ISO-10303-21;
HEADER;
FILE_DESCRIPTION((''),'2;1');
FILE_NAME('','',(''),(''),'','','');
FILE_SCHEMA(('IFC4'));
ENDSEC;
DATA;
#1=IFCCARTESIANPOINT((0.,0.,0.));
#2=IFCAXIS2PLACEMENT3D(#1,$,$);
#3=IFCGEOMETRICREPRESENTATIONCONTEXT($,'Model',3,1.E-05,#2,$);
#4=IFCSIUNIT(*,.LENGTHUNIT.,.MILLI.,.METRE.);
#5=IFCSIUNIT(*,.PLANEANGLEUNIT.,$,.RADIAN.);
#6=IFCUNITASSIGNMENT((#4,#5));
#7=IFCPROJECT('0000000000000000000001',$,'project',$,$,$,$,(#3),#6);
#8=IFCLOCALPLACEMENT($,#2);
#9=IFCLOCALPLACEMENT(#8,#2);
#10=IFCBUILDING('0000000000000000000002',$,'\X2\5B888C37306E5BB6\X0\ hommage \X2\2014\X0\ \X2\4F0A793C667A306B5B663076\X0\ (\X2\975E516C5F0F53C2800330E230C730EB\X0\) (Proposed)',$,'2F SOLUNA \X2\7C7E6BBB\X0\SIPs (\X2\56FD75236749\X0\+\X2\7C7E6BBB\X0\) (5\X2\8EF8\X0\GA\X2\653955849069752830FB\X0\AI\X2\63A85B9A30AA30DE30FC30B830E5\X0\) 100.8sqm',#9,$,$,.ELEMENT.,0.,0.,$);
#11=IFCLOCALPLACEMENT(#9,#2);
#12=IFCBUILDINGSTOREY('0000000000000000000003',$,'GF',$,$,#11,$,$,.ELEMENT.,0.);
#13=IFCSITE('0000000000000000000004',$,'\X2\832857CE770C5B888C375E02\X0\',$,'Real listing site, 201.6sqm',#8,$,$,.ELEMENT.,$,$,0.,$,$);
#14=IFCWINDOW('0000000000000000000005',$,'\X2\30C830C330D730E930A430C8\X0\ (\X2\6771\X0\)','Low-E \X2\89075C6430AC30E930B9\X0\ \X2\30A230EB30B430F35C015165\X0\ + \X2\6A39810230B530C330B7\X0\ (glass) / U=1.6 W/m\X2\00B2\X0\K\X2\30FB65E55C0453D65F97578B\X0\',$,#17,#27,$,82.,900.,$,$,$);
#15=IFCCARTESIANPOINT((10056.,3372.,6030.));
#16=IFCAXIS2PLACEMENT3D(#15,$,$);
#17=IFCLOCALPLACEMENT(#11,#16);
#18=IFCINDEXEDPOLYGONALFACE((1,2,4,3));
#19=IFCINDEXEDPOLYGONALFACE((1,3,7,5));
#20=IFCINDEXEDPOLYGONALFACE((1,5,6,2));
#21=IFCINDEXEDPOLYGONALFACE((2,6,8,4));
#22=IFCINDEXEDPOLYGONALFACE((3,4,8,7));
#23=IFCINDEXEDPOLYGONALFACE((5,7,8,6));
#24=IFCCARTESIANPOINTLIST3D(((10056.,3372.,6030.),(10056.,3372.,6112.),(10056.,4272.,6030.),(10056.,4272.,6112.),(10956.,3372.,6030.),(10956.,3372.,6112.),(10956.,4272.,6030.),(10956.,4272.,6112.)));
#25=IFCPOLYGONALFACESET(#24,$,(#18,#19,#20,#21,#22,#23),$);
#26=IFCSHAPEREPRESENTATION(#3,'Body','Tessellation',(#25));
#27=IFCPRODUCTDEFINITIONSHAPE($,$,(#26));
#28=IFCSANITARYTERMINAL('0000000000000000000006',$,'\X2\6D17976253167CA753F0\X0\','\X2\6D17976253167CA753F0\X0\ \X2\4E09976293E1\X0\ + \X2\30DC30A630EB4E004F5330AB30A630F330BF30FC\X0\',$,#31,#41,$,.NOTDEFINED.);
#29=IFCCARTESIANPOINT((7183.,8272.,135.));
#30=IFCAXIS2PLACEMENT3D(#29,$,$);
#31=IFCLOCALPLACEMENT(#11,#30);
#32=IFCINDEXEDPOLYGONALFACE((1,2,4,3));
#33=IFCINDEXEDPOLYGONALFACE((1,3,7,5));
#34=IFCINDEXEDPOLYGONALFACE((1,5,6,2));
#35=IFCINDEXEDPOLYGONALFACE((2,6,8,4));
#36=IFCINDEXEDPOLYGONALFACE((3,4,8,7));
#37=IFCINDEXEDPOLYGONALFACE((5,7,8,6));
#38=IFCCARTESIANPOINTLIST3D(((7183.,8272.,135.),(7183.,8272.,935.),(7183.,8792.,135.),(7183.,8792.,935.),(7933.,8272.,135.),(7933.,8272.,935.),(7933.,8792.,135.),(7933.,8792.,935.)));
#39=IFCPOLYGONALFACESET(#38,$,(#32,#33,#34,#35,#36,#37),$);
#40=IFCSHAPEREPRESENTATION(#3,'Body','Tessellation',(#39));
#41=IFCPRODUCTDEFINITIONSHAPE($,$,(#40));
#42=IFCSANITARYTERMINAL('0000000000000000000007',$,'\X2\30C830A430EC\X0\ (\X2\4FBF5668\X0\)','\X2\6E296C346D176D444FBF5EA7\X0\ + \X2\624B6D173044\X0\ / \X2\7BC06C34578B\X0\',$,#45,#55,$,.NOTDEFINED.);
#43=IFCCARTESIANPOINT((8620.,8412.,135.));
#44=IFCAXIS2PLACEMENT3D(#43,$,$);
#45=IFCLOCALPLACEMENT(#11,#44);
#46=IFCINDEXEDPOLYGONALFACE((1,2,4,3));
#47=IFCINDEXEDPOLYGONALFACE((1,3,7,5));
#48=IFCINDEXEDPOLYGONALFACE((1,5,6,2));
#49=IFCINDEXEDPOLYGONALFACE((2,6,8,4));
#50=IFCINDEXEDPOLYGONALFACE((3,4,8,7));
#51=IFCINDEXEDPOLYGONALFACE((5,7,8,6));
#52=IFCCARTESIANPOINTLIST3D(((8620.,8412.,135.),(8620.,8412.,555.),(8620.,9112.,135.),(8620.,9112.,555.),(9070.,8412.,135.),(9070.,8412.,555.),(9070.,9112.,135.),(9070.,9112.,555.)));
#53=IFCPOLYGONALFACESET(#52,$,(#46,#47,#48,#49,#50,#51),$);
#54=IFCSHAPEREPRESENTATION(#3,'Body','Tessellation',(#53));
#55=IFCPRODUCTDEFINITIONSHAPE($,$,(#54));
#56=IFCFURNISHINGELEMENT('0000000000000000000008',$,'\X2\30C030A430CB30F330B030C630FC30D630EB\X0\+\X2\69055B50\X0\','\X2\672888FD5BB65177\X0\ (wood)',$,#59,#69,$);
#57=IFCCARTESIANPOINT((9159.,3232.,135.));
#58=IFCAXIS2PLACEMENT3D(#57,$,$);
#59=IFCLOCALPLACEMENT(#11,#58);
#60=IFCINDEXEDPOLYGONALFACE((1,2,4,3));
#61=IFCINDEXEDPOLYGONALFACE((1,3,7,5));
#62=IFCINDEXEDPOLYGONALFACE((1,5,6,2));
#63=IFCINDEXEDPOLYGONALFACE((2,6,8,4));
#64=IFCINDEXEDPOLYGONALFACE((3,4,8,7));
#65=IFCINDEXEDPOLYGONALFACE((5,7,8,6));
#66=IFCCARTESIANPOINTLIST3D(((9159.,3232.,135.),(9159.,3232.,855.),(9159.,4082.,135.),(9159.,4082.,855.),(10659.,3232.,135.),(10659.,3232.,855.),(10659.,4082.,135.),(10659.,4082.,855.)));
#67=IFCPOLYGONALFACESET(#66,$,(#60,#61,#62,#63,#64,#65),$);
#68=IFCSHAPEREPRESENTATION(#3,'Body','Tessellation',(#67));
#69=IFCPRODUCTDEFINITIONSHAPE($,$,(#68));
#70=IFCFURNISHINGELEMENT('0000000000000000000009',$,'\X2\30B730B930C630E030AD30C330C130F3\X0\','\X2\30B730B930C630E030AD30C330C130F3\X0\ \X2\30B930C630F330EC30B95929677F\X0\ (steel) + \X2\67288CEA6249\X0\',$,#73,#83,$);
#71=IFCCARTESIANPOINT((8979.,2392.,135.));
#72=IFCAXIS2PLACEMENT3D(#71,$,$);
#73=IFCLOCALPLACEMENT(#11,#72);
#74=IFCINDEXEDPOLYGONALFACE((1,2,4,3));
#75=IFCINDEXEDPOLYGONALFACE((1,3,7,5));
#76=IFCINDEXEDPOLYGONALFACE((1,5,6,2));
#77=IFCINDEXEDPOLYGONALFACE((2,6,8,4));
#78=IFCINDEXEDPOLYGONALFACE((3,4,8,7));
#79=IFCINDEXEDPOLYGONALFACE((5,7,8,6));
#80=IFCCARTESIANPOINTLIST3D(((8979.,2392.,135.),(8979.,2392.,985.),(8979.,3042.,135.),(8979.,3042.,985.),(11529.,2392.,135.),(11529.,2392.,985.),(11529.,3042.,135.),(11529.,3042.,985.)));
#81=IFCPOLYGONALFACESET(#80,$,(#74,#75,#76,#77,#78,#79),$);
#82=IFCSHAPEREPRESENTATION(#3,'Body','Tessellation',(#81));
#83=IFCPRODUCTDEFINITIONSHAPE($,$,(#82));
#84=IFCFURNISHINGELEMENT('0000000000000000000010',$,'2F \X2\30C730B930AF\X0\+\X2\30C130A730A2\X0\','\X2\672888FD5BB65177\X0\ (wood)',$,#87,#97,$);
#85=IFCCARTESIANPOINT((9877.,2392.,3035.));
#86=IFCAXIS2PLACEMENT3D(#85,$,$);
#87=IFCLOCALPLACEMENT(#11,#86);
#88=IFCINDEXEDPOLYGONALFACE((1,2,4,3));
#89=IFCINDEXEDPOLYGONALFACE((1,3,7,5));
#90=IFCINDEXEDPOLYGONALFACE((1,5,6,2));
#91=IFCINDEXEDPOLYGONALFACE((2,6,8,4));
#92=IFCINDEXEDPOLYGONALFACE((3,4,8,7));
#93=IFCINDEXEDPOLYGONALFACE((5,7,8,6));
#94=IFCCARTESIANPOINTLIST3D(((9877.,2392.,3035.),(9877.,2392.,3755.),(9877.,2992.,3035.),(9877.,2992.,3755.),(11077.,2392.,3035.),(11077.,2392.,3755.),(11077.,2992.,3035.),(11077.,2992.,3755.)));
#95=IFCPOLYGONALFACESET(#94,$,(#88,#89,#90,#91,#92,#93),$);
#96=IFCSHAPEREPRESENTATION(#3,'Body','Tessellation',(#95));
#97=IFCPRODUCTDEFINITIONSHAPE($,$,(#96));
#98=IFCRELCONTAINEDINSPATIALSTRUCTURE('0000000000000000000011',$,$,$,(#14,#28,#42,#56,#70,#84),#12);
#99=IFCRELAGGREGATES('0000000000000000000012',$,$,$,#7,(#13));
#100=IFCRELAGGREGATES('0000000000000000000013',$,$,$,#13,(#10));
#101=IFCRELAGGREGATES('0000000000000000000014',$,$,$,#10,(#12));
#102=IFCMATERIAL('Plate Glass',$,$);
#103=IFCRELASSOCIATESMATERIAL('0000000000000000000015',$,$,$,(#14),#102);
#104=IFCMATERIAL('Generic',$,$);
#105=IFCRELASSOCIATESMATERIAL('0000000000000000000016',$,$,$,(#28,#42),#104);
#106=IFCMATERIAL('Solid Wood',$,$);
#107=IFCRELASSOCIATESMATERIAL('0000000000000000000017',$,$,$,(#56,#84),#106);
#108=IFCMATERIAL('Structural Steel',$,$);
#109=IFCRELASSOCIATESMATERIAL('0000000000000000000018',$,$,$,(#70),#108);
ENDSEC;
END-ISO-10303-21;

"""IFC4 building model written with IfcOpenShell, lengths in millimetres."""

from ifc_helpers import new_model, si_unit, frame, frame_2d, origin, place, context, project, spatial, rectangle, extrude, material, element, save


model = new_model("IFC4")

# Units and contexts
model_context = context("Model", 3, precision=1e-05, world=origin())
ifc_project = project(units=[si_unit("LENGTHUNIT", "METRE", prefix="MILLI"), si_unit("PLANEANGLEUNIT", "RADIAN")], contexts=[model_context])

# Site, building, storey
site_placement = place(None, origin())
site = spatial("IfcSite", under=ifc_project, at=site_placement, Name="茨城県守谷市", ObjectType="Real listing site, 201.6sqm", CompositionType="ELEMENT", RefElevation=0.0)
building_placement = place(site_placement, origin())
building = spatial("IfcBuilding", under=site, at=building_placement, Name="守谷の家 hommage — 伊礼智に学ぶ (非公式参考モデル) (Proposed)", ObjectType="2F SOLUNA 籾殻SIPs (国産杉+籾殻) (5軸GA改善適用・AI推定オマージュ) 100.8sqm", CompositionType="ELEMENT", ElevationOfRefHeight=0.0, ElevationOfTerrain=0.0)
storey_placement = place(building_placement, origin())
storey = spatial("IfcBuildingStorey", under=building, at=storey_placement, Name="GF", CompositionType="ELEMENT", Elevation=0.0)

# Shared definitions
ifc_material_1 = material(Name="Solid Wood")

# Shared definitions
ifc_material_2 = material(Name="Plate Glass")

# Window
window_1_placement = place(storey_placement, frame((10056.0, 3372.0, 6030.0)))
element("IfcWindow", 1, at=window_1_placement, inside=storey, material=ifc_material_2, Name="トップライト (東)", Description="Low-E 複層ガラス アルゴン封入 + 樹脂サッシ (glass) / U=1.6 W/m²K・日射取得型", OverallHeight=82.0, OverallWidth=900.0, context=model_context, shape_type="SweptSolid", body=[
    extrude(rectangle(XDim=900.0, YDim=900.0, at=frame_2d((450.0, 450.0))), frame((10056.0, 3372.0, 6030.0)), (0.0, 0.0, 1.0), 82.0),
])

# Sanitary terminals
ifc_material_3 = material(Name="Generic")
sanitary_terminal_1_placement = place(storey_placement, frame((7183.0, 8272.0, 135.0)))
element("IfcSanitaryTerminal", 2, at=sanitary_terminal_1_placement, inside=storey, material=ifc_material_3, Name="洗面化粧台", Description="洗面化粧台 三面鏡 + ボウル一体カウンター", PredefinedType="NOTDEFINED", context=model_context, shape_type="SweptSolid", body=[
    extrude(rectangle(XDim=750.0, YDim=520.0, at=frame_2d((375.0, 260.0))), frame((7183.0, 8272.0, 135.0)), (0.0, 0.0, 1.0), 800.0),
])
sanitary_terminal_2_placement = place(storey_placement, frame((8620.0, 8412.0, 135.0)))
element("IfcSanitaryTerminal", 3, at=sanitary_terminal_2_placement, inside=storey, material=ifc_material_3, Name="トイレ (便器)", Description="温水洗浄便座 + 手洗い / 節水型", PredefinedType="NOTDEFINED", context=model_context, shape_type="SweptSolid", body=[
    extrude(rectangle(XDim=450.0, YDim=700.0, at=frame_2d((225.0, 350.0))), frame((8620.0, 8412.0, 135.0)), (0.0, 0.0, 1.0), 420.0),
])

# Furnishing elements
furnishing_1_placement = place(storey_placement, frame((9159.0, 3232.0, 135.0)))
element("IfcFurnishingElement", 4, at=furnishing_1_placement, inside=storey, material=ifc_material_1, Name="ダイニングテーブル+椅子", Description="木製家具 (wood)", context=model_context, shape_type="SweptSolid", body=[
    extrude(rectangle(XDim=1500.0, YDim=850.0, at=frame_2d((750.0, 425.0))), frame((9159.0, 3232.0, 135.0)), (0.0, 0.0, 1.0), 720.0),
])
ifc_material_4 = material(Name="Structural Steel")
furnishing_2_placement = place(storey_placement, frame((8979.0, 2392.0, 135.0)))
element("IfcFurnishingElement", 5, at=furnishing_2_placement, inside=storey, material=ifc_material_4, Name="システムキッチン", Description="システムキッチン ステンレス天板 (steel) + 木質扉", context=model_context, shape_type="SweptSolid", body=[
    extrude(rectangle(XDim=2550.0, YDim=650.0, at=frame_2d((1275.0, 325.0))), frame((8979.0, 2392.0, 135.0)), (0.0, 0.0, 1.0), 850.0),
])
furnishing_3_placement = place(storey_placement, frame((9877.0, 2392.0, 3035.0)))
element("IfcFurnishingElement", 6, at=furnishing_3_placement, inside=storey, material=ifc_material_1, Name="2F デスク+チェア", Description="木製家具 (wood)", context=model_context, shape_type="SweptSolid", body=[
    extrude(rectangle(XDim=1200.0, YDim=600.0, at=frame_2d((600.0, 300.0))), frame((9877.0, 2392.0, 3035.0)), (0.0, 0.0, 1.0), 720.0),
])

save(model, "model.ifc")
